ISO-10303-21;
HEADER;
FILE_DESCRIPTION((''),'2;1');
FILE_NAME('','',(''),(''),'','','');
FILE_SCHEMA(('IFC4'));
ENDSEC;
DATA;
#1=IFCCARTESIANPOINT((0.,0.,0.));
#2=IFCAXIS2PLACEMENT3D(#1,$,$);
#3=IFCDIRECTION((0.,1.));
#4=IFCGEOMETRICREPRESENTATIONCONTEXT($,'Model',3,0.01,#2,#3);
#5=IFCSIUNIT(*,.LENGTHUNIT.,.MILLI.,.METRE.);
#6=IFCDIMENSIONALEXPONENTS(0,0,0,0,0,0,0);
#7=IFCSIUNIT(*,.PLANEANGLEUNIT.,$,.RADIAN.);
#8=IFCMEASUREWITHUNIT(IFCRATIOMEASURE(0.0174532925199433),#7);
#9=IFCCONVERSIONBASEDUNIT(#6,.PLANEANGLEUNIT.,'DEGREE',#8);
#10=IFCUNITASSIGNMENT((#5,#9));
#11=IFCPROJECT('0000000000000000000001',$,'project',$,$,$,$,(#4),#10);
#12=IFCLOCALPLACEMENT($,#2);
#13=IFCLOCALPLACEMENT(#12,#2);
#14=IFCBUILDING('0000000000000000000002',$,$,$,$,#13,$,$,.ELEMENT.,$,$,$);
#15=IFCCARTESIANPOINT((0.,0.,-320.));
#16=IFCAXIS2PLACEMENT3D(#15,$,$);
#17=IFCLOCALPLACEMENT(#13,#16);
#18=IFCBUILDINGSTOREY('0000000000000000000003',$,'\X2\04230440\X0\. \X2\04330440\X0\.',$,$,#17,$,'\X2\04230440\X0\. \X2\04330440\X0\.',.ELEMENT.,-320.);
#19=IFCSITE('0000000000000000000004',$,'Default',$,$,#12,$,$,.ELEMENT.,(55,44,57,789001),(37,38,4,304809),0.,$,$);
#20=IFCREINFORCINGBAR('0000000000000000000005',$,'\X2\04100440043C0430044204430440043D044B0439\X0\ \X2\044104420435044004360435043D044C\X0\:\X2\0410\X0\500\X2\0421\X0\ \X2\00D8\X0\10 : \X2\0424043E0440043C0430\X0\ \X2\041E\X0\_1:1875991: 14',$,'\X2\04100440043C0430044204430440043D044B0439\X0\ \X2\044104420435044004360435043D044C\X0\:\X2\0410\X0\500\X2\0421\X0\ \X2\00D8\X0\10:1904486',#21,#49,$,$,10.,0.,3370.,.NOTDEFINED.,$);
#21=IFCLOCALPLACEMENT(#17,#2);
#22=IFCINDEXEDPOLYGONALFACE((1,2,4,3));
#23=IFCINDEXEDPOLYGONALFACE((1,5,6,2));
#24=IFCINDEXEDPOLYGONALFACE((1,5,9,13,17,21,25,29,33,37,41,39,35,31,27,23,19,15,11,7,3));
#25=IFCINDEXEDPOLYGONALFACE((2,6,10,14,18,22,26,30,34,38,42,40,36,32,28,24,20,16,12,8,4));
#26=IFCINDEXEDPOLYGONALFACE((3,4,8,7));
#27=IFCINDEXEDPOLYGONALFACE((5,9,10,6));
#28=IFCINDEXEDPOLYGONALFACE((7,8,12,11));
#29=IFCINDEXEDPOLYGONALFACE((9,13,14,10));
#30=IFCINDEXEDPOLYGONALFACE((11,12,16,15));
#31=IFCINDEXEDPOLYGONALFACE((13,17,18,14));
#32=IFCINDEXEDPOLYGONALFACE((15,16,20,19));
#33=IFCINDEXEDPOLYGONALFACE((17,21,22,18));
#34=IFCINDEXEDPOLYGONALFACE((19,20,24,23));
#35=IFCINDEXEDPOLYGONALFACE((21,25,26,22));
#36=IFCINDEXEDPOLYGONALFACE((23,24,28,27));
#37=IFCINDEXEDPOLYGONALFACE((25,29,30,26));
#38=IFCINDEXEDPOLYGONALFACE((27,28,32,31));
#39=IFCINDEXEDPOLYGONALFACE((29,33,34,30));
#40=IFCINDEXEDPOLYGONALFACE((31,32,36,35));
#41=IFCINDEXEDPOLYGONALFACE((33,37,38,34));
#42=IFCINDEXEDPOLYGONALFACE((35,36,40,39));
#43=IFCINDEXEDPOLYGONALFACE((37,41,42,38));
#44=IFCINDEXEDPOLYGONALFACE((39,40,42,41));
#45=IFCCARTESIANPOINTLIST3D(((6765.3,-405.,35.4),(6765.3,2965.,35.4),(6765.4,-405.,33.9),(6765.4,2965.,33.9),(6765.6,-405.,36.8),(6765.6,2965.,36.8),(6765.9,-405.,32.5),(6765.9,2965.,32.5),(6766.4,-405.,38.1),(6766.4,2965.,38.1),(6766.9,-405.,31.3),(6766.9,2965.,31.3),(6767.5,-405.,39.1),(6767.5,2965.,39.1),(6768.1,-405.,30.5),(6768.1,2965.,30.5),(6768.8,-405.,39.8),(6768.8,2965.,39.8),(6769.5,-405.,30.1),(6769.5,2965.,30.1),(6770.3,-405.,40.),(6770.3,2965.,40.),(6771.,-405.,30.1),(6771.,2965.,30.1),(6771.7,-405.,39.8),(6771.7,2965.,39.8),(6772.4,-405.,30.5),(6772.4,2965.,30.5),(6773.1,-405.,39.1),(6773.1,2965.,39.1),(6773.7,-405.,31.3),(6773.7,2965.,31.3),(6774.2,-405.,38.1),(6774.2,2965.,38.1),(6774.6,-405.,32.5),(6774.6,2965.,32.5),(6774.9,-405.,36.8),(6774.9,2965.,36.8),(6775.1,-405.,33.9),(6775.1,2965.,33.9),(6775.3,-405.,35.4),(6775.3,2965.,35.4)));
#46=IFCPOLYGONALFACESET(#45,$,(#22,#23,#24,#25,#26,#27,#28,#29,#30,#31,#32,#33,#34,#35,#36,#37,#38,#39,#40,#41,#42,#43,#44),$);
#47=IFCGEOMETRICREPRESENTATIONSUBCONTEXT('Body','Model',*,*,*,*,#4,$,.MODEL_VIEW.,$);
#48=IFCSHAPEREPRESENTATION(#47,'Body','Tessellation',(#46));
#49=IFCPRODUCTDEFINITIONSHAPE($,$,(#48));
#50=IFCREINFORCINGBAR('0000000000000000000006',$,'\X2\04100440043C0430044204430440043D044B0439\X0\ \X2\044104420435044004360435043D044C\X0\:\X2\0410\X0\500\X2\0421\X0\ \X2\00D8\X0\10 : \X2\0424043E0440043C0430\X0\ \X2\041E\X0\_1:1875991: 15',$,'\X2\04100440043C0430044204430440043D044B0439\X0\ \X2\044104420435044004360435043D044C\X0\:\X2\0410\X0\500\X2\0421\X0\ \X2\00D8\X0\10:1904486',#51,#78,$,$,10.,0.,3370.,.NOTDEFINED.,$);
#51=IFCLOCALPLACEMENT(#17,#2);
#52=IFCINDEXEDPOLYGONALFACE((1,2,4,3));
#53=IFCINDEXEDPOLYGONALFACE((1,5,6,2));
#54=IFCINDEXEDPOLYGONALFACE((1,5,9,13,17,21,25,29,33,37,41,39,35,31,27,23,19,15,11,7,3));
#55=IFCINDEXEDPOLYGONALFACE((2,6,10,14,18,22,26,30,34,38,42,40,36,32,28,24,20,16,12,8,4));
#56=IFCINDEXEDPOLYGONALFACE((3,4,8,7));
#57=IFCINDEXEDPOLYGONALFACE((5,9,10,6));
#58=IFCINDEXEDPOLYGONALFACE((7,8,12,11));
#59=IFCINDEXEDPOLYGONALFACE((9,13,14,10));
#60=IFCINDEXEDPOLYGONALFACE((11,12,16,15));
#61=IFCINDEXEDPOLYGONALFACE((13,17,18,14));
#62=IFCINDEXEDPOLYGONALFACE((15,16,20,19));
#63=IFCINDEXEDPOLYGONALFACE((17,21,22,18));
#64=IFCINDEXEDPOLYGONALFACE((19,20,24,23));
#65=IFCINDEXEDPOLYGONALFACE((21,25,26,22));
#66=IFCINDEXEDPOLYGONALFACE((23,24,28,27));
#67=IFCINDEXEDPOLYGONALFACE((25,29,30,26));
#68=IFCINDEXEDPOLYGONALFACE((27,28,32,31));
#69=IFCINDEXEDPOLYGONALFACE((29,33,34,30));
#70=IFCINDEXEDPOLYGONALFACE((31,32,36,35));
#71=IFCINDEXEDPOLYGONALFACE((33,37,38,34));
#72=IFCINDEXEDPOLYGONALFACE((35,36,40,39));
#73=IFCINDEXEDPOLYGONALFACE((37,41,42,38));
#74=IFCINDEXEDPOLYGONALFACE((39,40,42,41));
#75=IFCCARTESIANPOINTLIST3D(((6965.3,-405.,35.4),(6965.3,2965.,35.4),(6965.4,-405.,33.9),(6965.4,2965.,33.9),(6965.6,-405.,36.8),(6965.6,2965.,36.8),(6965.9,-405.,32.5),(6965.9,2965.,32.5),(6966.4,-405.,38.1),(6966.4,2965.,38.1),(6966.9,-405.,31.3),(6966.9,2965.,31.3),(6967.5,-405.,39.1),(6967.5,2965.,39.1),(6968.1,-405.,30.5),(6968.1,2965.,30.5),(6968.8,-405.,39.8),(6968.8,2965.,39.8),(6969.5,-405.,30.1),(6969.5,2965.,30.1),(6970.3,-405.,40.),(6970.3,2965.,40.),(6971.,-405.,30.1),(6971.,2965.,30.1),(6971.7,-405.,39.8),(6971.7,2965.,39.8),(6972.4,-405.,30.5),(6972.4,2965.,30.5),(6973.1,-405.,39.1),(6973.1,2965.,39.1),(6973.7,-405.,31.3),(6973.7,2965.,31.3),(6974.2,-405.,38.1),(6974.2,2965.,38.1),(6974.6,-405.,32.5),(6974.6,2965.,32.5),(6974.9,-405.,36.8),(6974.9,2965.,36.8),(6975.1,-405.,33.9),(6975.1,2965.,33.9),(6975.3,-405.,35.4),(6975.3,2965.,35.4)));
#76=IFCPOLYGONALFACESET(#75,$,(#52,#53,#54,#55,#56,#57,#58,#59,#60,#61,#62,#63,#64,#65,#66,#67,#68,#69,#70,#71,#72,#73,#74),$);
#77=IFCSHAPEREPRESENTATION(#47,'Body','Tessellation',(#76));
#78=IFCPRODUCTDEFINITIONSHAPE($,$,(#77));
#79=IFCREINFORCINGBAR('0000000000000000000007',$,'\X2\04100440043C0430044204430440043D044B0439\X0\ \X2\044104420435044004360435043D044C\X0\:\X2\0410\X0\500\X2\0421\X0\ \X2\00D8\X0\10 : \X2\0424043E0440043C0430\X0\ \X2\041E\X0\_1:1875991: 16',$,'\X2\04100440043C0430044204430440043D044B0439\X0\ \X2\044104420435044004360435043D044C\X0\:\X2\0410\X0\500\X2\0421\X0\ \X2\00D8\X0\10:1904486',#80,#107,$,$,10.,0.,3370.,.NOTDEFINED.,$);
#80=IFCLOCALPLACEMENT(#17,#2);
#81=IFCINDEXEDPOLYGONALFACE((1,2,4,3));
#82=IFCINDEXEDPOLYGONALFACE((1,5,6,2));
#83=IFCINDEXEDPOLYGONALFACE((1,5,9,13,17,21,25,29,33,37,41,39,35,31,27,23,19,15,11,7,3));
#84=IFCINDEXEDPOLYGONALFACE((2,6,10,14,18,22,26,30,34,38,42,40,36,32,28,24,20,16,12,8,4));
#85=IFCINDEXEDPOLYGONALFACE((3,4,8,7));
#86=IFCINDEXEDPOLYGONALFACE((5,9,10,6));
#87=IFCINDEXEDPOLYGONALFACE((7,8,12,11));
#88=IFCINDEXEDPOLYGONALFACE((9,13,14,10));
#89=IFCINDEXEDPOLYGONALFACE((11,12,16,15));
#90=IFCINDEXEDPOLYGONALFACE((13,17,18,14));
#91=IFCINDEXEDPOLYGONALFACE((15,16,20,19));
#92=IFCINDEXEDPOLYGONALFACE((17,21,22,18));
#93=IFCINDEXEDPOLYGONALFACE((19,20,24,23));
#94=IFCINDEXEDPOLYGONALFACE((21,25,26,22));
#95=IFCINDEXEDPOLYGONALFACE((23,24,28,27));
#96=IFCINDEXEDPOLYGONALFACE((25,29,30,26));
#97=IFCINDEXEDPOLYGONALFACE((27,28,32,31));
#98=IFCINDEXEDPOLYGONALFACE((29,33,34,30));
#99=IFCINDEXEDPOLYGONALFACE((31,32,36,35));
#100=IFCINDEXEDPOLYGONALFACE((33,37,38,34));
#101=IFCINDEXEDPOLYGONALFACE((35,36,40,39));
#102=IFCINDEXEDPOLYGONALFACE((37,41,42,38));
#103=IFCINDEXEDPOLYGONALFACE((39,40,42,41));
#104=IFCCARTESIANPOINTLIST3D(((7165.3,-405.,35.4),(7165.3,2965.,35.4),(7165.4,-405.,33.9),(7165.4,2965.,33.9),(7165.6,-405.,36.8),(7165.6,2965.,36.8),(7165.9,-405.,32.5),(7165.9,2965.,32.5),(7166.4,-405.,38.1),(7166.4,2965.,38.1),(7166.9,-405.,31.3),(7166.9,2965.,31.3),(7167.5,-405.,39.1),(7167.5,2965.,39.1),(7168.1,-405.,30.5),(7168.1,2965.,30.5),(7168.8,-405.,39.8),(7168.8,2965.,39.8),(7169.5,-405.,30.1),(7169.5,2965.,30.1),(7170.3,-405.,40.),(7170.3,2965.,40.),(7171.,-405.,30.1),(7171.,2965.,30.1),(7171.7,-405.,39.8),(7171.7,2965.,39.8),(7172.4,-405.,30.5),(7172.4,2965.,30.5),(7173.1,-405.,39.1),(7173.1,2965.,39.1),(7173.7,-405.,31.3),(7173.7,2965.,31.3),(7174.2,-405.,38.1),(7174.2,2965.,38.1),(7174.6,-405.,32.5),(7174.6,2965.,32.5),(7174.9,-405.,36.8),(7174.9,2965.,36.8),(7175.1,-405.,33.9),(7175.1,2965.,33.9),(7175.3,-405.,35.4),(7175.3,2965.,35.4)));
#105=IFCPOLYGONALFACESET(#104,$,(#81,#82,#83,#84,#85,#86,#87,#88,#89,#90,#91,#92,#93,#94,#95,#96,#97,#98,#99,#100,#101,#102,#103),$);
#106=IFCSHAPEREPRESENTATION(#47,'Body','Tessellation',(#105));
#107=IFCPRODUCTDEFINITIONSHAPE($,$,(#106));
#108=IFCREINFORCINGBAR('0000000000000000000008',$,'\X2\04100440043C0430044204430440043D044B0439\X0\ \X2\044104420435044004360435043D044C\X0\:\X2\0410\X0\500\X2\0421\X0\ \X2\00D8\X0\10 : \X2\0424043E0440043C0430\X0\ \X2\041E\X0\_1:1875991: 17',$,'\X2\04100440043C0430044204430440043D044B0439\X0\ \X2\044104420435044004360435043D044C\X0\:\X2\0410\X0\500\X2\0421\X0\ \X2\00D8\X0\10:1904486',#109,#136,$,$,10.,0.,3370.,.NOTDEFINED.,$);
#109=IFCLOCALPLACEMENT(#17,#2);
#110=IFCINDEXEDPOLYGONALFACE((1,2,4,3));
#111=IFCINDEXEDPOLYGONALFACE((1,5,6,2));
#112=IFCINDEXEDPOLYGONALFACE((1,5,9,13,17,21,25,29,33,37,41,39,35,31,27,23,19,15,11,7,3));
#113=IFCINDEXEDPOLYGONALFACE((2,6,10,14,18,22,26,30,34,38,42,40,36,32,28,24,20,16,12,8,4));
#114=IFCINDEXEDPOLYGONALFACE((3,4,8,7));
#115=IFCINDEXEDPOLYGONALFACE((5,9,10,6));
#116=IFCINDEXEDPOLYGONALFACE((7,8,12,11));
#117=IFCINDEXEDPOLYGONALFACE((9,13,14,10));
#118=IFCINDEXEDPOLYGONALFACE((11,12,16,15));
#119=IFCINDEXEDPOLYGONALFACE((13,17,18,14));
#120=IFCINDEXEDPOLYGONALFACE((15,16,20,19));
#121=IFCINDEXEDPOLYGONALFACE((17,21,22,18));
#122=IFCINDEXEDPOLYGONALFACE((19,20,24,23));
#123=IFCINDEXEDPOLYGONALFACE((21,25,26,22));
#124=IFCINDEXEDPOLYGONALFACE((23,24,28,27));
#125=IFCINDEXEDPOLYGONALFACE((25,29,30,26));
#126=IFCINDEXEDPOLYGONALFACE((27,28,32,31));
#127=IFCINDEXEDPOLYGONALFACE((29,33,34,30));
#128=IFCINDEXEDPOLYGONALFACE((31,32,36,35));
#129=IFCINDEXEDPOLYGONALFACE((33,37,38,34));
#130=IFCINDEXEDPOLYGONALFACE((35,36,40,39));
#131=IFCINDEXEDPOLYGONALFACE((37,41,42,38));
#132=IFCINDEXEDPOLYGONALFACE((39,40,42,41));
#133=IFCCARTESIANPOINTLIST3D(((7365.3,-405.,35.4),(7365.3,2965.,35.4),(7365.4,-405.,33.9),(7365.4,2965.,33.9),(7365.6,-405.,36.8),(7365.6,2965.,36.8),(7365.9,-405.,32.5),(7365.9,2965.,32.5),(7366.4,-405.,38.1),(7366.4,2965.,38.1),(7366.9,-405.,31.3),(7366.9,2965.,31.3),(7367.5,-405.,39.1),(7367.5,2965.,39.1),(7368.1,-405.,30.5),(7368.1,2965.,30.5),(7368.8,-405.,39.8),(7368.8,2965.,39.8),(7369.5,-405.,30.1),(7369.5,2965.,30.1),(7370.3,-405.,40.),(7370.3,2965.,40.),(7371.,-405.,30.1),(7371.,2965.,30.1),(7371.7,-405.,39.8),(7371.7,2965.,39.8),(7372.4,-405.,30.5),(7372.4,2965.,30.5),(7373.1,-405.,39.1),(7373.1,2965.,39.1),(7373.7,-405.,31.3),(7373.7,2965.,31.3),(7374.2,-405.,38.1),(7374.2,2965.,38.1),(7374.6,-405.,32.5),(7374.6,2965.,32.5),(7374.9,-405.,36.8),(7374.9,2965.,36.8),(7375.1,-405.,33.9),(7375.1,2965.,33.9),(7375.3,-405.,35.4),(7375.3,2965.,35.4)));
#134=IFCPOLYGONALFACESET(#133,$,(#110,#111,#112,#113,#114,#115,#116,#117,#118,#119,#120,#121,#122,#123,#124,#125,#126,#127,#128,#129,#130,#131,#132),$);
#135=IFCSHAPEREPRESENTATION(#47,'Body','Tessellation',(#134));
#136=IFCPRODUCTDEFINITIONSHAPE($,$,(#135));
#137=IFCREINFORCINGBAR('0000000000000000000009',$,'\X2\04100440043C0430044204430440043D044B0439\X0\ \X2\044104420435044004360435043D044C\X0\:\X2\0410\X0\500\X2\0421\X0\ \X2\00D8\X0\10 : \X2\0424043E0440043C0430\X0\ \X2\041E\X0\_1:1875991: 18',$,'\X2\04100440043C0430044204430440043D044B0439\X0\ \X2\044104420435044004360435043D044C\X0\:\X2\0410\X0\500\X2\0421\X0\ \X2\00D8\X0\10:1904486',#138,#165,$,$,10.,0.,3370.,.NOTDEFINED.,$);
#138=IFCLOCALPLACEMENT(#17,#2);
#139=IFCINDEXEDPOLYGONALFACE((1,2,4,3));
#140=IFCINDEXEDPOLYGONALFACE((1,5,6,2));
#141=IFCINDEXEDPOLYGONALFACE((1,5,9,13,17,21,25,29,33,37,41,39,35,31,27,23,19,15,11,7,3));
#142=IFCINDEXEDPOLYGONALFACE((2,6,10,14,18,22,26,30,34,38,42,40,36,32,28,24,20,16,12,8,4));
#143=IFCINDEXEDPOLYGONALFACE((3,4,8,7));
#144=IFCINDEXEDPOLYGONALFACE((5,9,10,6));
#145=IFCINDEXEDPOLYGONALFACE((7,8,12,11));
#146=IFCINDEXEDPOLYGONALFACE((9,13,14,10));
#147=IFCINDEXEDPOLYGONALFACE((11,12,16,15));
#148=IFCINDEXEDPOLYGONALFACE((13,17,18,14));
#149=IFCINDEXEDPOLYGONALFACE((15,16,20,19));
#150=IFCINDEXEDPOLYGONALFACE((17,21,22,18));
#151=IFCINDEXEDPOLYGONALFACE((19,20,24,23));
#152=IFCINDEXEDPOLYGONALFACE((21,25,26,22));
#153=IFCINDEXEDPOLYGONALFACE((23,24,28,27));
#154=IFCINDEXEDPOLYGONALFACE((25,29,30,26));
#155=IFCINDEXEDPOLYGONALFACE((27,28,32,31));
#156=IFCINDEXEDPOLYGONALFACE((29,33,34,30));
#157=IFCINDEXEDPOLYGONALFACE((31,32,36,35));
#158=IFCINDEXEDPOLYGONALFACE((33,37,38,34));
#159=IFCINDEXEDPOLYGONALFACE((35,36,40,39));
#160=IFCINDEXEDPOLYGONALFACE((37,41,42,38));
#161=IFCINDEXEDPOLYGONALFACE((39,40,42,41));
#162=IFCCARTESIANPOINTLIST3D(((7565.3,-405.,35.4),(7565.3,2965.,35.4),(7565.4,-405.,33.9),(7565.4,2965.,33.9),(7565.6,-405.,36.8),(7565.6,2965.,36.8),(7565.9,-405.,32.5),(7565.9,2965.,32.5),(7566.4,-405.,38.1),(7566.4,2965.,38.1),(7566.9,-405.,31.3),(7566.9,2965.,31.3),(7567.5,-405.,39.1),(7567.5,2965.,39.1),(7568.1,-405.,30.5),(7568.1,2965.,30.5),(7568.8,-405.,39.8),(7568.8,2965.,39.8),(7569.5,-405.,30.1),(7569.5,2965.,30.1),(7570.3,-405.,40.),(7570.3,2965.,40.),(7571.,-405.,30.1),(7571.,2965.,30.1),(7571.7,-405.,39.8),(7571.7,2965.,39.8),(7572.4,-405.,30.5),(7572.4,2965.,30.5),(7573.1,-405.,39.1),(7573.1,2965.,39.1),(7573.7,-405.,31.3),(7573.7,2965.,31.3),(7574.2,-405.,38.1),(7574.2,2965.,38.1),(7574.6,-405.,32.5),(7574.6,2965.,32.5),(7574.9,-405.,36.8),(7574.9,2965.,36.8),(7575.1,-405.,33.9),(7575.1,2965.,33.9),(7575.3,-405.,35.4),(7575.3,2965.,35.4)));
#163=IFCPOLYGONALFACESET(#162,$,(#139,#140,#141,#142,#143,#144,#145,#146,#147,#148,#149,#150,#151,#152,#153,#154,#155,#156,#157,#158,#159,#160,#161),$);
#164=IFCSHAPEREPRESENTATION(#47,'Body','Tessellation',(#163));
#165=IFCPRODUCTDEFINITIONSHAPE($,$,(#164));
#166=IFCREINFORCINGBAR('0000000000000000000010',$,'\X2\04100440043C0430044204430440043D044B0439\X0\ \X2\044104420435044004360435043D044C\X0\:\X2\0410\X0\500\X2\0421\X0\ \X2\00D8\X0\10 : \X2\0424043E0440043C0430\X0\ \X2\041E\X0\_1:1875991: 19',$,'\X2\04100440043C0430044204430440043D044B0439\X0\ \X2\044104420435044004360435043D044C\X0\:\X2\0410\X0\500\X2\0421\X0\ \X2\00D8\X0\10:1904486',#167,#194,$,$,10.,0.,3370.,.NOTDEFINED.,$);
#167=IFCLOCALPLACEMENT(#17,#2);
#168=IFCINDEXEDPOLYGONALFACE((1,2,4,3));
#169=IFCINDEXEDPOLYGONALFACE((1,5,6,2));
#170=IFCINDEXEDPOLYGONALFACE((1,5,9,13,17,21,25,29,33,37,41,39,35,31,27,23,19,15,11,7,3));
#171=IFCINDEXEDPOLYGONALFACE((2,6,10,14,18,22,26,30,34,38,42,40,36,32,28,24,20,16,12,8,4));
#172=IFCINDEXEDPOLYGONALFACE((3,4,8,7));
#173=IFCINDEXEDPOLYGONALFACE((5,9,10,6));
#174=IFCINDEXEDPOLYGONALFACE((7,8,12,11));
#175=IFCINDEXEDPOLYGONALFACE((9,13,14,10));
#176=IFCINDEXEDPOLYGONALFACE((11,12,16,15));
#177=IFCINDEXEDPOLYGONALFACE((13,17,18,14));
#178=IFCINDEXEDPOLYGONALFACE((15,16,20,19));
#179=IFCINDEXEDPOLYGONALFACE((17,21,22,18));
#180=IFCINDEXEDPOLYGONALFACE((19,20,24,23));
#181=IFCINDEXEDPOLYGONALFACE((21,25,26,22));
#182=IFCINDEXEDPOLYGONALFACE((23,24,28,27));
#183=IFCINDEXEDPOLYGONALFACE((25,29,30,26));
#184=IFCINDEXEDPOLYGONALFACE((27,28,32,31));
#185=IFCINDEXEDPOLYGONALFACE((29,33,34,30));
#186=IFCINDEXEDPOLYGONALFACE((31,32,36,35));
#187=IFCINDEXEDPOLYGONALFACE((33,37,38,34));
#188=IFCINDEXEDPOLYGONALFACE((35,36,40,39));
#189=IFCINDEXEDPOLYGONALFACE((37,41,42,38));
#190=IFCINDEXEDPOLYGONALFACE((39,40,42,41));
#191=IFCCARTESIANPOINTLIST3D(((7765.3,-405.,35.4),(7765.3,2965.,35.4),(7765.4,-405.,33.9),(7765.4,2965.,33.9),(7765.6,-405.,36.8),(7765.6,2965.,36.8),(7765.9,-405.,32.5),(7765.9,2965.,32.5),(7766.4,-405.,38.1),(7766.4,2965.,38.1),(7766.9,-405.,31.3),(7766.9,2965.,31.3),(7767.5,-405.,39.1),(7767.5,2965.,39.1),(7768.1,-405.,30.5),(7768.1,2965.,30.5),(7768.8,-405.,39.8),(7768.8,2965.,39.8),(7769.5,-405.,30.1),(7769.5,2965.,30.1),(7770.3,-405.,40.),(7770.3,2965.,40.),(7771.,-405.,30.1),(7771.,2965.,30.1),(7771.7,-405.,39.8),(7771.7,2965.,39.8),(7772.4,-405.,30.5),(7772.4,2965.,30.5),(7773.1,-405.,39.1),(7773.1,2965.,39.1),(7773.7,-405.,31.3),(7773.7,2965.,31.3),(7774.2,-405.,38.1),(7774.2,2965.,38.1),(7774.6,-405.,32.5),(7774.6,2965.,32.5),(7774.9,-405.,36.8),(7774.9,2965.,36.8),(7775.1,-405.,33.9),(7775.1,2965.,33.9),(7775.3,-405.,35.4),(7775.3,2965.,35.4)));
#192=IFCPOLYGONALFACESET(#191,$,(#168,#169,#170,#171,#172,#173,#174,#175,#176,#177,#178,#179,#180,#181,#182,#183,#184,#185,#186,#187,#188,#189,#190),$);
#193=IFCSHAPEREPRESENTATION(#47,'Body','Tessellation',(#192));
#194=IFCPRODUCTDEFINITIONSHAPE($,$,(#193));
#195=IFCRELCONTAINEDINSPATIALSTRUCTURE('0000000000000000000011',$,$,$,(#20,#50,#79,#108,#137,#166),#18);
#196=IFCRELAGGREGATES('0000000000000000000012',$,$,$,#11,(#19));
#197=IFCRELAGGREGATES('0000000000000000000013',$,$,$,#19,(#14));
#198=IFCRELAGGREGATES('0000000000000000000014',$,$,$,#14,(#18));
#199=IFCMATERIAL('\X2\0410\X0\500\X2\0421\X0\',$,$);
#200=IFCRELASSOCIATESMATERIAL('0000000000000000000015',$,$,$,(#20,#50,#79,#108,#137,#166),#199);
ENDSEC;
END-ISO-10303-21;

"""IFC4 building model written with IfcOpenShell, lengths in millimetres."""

from ifc_helpers import new_model, entity, si_unit, converted_unit, direction, frame, origin, place, context, subcontext, project, spatial, material, element, save


model = new_model("IFC4")

# Units and contexts
model_context = context("Model", 3, precision=0.01, world=origin(), true_north=direction((0.0, 1.0)))
body_context = subcontext(model_context, "Body", "Model", "MODEL_VIEW")
ifc_project = project(units=[si_unit("LENGTHUNIT", "METRE", prefix="MILLI"), converted_unit("PLANEANGLEUNIT", "DEGREE", entity("IfcRatioMeasure", 0.0174532925199433), si_unit("PLANEANGLEUNIT", "RADIAN"), dimensions=[0, 0, 0, 0, 0, 0, 0])], contexts=[model_context])

# Site, building, storey
site_placement = place(None, origin())
site = spatial("IfcSite", under=ifc_project, at=site_placement, Name="Default", CompositionType="ELEMENT", RefLatitude=(55, 44, 57, 789001), RefLongitude=(37, 38, 4, 304809), RefElevation=0.0)
building_placement = place(site_placement, origin())
building = spatial("IfcBuilding", under=site, at=building_placement, CompositionType="ELEMENT")
storey_placement = place(building_placement, frame((0.0, 0.0, -320.0)))
storey = spatial("IfcBuildingStorey", under=building, at=storey_placement, Name="Ур. гр.", LongName="Ур. гр.", CompositionType="ELEMENT", Elevation=-320.0)

# Reinforcing bars
ifc_material_1 = material(Name="А500С")
reinforcing_bar_1_placement = place(storey_placement, origin())
element("IfcReinforcingBar", 1, at=reinforcing_bar_1_placement, inside=storey, material=ifc_material_1, Name="Арматурный стержень:А500С Ø10 : Форма О_1:1875991: 14", ObjectType="Арматурный стержень:А500С Ø10:1904486", BarLength=3370.0, CrossSectionArea=0.0, NominalDiameter=10.0, PredefinedType="NOTDEFINED", context=body_context, shape_type="AdvancedSweptSolid", body=[
    entity("IfcSweptDiskSolid", entity("IfcCompositeCurve", [entity("IfcCompositeCurveSegment", "CONTINUOUS", True, entity("IfcPolyline", [entity("IfcCartesianPoint", [6770.3, -405.0, 35.0]), entity("IfcCartesianPoint", [6770.3, 2965.0, 35.0])]))], False), 5.0, None, 0.0, 1.0),
])
reinforcing_bar_2_placement = place(storey_placement, origin())
element("IfcReinforcingBar", 2, at=reinforcing_bar_2_placement, inside=storey, material=ifc_material_1, Name="Арматурный стержень:А500С Ø10 : Форма О_1:1875991: 15", ObjectType="Арматурный стержень:А500С Ø10:1904486", BarLength=3370.0, CrossSectionArea=0.0, NominalDiameter=10.0, PredefinedType="NOTDEFINED", context=body_context, shape_type="AdvancedSweptSolid", body=[
    entity("IfcSweptDiskSolid", entity("IfcCompositeCurve", [entity("IfcCompositeCurveSegment", "CONTINUOUS", True, entity("IfcPolyline", [entity("IfcCartesianPoint", [6970.3, -405.0, 35.0]), entity("IfcCartesianPoint", [6970.3, 2965.0, 35.0])]))], False), 5.0, None, 0.0, 1.0),
])
reinforcing_bar_3_placement = place(storey_placement, origin())
element("IfcReinforcingBar", 3, at=reinforcing_bar_3_placement, inside=storey, material=ifc_material_1, Name="Арматурный стержень:А500С Ø10 : Форма О_1:1875991: 16", ObjectType="Арматурный стержень:А500С Ø10:1904486", BarLength=3370.0, CrossSectionArea=0.0, NominalDiameter=10.0, PredefinedType="NOTDEFINED", context=body_context, shape_type="AdvancedSweptSolid", body=[
    entity("IfcSweptDiskSolid", entity("IfcCompositeCurve", [entity("IfcCompositeCurveSegment", "CONTINUOUS", True, entity("IfcPolyline", [entity("IfcCartesianPoint", [7170.3, -405.0, 35.0]), entity("IfcCartesianPoint", [7170.3, 2965.0, 35.0])]))], False), 5.0, None, 0.0, 1.0),
])
reinforcing_bar_4_placement = place(storey_placement, origin())
element("IfcReinforcingBar", 4, at=reinforcing_bar_4_placement, inside=storey, material=ifc_material_1, Name="Арматурный стержень:А500С Ø10 : Форма О_1:1875991: 17", ObjectType="Арматурный стержень:А500С Ø10:1904486", BarLength=3370.0, CrossSectionArea=0.0, NominalDiameter=10.0, PredefinedType="NOTDEFINED", context=body_context, shape_type="AdvancedSweptSolid", body=[
    entity("IfcSweptDiskSolid", entity("IfcCompositeCurve", [entity("IfcCompositeCurveSegment", "CONTINUOUS", True, entity("IfcPolyline", [entity("IfcCartesianPoint", [7370.3, -405.0, 35.0]), entity("IfcCartesianPoint", [7370.3, 2965.0, 35.0])]))], False), 5.0, None, 0.0, 1.0),
])
reinforcing_bar_5_placement = place(storey_placement, origin())
element("IfcReinforcingBar", 5, at=reinforcing_bar_5_placement, inside=storey, material=ifc_material_1, Name="Арматурный стержень:А500С Ø10 : Форма О_1:1875991: 18", ObjectType="Арматурный стержень:А500С Ø10:1904486", BarLength=3370.0, CrossSectionArea=0.0, NominalDiameter=10.0, PredefinedType="NOTDEFINED", context=body_context, shape_type="AdvancedSweptSolid", body=[
    entity("IfcSweptDiskSolid", entity("IfcCompositeCurve", [entity("IfcCompositeCurveSegment", "CONTINUOUS", True, entity("IfcPolyline", [entity("IfcCartesianPoint", [7570.3, -405.0, 35.0]), entity("IfcCartesianPoint", [7570.3, 2965.0, 35.0])]))], False), 5.0, None, 0.0, 1.0),
])
reinforcing_bar_6_placement = place(storey_placement, origin())
element("IfcReinforcingBar", 6, at=reinforcing_bar_6_placement, inside=storey, material=ifc_material_1, Name="Арматурный стержень:А500С Ø10 : Форма О_1:1875991: 19", ObjectType="Арматурный стержень:А500С Ø10:1904486", BarLength=3370.0, CrossSectionArea=0.0, NominalDiameter=10.0, PredefinedType="NOTDEFINED", context=body_context, shape_type="AdvancedSweptSolid", body=[
    entity("IfcSweptDiskSolid", entity("IfcCompositeCurve", [entity("IfcCompositeCurveSegment", "CONTINUOUS", True, entity("IfcPolyline", [entity("IfcCartesianPoint", [7770.3, -405.0, 35.0]), entity("IfcCartesianPoint", [7770.3, 2965.0, 35.0])]))], False), 5.0, None, 0.0, 1.0),
])

save(model, "model.ifc")
